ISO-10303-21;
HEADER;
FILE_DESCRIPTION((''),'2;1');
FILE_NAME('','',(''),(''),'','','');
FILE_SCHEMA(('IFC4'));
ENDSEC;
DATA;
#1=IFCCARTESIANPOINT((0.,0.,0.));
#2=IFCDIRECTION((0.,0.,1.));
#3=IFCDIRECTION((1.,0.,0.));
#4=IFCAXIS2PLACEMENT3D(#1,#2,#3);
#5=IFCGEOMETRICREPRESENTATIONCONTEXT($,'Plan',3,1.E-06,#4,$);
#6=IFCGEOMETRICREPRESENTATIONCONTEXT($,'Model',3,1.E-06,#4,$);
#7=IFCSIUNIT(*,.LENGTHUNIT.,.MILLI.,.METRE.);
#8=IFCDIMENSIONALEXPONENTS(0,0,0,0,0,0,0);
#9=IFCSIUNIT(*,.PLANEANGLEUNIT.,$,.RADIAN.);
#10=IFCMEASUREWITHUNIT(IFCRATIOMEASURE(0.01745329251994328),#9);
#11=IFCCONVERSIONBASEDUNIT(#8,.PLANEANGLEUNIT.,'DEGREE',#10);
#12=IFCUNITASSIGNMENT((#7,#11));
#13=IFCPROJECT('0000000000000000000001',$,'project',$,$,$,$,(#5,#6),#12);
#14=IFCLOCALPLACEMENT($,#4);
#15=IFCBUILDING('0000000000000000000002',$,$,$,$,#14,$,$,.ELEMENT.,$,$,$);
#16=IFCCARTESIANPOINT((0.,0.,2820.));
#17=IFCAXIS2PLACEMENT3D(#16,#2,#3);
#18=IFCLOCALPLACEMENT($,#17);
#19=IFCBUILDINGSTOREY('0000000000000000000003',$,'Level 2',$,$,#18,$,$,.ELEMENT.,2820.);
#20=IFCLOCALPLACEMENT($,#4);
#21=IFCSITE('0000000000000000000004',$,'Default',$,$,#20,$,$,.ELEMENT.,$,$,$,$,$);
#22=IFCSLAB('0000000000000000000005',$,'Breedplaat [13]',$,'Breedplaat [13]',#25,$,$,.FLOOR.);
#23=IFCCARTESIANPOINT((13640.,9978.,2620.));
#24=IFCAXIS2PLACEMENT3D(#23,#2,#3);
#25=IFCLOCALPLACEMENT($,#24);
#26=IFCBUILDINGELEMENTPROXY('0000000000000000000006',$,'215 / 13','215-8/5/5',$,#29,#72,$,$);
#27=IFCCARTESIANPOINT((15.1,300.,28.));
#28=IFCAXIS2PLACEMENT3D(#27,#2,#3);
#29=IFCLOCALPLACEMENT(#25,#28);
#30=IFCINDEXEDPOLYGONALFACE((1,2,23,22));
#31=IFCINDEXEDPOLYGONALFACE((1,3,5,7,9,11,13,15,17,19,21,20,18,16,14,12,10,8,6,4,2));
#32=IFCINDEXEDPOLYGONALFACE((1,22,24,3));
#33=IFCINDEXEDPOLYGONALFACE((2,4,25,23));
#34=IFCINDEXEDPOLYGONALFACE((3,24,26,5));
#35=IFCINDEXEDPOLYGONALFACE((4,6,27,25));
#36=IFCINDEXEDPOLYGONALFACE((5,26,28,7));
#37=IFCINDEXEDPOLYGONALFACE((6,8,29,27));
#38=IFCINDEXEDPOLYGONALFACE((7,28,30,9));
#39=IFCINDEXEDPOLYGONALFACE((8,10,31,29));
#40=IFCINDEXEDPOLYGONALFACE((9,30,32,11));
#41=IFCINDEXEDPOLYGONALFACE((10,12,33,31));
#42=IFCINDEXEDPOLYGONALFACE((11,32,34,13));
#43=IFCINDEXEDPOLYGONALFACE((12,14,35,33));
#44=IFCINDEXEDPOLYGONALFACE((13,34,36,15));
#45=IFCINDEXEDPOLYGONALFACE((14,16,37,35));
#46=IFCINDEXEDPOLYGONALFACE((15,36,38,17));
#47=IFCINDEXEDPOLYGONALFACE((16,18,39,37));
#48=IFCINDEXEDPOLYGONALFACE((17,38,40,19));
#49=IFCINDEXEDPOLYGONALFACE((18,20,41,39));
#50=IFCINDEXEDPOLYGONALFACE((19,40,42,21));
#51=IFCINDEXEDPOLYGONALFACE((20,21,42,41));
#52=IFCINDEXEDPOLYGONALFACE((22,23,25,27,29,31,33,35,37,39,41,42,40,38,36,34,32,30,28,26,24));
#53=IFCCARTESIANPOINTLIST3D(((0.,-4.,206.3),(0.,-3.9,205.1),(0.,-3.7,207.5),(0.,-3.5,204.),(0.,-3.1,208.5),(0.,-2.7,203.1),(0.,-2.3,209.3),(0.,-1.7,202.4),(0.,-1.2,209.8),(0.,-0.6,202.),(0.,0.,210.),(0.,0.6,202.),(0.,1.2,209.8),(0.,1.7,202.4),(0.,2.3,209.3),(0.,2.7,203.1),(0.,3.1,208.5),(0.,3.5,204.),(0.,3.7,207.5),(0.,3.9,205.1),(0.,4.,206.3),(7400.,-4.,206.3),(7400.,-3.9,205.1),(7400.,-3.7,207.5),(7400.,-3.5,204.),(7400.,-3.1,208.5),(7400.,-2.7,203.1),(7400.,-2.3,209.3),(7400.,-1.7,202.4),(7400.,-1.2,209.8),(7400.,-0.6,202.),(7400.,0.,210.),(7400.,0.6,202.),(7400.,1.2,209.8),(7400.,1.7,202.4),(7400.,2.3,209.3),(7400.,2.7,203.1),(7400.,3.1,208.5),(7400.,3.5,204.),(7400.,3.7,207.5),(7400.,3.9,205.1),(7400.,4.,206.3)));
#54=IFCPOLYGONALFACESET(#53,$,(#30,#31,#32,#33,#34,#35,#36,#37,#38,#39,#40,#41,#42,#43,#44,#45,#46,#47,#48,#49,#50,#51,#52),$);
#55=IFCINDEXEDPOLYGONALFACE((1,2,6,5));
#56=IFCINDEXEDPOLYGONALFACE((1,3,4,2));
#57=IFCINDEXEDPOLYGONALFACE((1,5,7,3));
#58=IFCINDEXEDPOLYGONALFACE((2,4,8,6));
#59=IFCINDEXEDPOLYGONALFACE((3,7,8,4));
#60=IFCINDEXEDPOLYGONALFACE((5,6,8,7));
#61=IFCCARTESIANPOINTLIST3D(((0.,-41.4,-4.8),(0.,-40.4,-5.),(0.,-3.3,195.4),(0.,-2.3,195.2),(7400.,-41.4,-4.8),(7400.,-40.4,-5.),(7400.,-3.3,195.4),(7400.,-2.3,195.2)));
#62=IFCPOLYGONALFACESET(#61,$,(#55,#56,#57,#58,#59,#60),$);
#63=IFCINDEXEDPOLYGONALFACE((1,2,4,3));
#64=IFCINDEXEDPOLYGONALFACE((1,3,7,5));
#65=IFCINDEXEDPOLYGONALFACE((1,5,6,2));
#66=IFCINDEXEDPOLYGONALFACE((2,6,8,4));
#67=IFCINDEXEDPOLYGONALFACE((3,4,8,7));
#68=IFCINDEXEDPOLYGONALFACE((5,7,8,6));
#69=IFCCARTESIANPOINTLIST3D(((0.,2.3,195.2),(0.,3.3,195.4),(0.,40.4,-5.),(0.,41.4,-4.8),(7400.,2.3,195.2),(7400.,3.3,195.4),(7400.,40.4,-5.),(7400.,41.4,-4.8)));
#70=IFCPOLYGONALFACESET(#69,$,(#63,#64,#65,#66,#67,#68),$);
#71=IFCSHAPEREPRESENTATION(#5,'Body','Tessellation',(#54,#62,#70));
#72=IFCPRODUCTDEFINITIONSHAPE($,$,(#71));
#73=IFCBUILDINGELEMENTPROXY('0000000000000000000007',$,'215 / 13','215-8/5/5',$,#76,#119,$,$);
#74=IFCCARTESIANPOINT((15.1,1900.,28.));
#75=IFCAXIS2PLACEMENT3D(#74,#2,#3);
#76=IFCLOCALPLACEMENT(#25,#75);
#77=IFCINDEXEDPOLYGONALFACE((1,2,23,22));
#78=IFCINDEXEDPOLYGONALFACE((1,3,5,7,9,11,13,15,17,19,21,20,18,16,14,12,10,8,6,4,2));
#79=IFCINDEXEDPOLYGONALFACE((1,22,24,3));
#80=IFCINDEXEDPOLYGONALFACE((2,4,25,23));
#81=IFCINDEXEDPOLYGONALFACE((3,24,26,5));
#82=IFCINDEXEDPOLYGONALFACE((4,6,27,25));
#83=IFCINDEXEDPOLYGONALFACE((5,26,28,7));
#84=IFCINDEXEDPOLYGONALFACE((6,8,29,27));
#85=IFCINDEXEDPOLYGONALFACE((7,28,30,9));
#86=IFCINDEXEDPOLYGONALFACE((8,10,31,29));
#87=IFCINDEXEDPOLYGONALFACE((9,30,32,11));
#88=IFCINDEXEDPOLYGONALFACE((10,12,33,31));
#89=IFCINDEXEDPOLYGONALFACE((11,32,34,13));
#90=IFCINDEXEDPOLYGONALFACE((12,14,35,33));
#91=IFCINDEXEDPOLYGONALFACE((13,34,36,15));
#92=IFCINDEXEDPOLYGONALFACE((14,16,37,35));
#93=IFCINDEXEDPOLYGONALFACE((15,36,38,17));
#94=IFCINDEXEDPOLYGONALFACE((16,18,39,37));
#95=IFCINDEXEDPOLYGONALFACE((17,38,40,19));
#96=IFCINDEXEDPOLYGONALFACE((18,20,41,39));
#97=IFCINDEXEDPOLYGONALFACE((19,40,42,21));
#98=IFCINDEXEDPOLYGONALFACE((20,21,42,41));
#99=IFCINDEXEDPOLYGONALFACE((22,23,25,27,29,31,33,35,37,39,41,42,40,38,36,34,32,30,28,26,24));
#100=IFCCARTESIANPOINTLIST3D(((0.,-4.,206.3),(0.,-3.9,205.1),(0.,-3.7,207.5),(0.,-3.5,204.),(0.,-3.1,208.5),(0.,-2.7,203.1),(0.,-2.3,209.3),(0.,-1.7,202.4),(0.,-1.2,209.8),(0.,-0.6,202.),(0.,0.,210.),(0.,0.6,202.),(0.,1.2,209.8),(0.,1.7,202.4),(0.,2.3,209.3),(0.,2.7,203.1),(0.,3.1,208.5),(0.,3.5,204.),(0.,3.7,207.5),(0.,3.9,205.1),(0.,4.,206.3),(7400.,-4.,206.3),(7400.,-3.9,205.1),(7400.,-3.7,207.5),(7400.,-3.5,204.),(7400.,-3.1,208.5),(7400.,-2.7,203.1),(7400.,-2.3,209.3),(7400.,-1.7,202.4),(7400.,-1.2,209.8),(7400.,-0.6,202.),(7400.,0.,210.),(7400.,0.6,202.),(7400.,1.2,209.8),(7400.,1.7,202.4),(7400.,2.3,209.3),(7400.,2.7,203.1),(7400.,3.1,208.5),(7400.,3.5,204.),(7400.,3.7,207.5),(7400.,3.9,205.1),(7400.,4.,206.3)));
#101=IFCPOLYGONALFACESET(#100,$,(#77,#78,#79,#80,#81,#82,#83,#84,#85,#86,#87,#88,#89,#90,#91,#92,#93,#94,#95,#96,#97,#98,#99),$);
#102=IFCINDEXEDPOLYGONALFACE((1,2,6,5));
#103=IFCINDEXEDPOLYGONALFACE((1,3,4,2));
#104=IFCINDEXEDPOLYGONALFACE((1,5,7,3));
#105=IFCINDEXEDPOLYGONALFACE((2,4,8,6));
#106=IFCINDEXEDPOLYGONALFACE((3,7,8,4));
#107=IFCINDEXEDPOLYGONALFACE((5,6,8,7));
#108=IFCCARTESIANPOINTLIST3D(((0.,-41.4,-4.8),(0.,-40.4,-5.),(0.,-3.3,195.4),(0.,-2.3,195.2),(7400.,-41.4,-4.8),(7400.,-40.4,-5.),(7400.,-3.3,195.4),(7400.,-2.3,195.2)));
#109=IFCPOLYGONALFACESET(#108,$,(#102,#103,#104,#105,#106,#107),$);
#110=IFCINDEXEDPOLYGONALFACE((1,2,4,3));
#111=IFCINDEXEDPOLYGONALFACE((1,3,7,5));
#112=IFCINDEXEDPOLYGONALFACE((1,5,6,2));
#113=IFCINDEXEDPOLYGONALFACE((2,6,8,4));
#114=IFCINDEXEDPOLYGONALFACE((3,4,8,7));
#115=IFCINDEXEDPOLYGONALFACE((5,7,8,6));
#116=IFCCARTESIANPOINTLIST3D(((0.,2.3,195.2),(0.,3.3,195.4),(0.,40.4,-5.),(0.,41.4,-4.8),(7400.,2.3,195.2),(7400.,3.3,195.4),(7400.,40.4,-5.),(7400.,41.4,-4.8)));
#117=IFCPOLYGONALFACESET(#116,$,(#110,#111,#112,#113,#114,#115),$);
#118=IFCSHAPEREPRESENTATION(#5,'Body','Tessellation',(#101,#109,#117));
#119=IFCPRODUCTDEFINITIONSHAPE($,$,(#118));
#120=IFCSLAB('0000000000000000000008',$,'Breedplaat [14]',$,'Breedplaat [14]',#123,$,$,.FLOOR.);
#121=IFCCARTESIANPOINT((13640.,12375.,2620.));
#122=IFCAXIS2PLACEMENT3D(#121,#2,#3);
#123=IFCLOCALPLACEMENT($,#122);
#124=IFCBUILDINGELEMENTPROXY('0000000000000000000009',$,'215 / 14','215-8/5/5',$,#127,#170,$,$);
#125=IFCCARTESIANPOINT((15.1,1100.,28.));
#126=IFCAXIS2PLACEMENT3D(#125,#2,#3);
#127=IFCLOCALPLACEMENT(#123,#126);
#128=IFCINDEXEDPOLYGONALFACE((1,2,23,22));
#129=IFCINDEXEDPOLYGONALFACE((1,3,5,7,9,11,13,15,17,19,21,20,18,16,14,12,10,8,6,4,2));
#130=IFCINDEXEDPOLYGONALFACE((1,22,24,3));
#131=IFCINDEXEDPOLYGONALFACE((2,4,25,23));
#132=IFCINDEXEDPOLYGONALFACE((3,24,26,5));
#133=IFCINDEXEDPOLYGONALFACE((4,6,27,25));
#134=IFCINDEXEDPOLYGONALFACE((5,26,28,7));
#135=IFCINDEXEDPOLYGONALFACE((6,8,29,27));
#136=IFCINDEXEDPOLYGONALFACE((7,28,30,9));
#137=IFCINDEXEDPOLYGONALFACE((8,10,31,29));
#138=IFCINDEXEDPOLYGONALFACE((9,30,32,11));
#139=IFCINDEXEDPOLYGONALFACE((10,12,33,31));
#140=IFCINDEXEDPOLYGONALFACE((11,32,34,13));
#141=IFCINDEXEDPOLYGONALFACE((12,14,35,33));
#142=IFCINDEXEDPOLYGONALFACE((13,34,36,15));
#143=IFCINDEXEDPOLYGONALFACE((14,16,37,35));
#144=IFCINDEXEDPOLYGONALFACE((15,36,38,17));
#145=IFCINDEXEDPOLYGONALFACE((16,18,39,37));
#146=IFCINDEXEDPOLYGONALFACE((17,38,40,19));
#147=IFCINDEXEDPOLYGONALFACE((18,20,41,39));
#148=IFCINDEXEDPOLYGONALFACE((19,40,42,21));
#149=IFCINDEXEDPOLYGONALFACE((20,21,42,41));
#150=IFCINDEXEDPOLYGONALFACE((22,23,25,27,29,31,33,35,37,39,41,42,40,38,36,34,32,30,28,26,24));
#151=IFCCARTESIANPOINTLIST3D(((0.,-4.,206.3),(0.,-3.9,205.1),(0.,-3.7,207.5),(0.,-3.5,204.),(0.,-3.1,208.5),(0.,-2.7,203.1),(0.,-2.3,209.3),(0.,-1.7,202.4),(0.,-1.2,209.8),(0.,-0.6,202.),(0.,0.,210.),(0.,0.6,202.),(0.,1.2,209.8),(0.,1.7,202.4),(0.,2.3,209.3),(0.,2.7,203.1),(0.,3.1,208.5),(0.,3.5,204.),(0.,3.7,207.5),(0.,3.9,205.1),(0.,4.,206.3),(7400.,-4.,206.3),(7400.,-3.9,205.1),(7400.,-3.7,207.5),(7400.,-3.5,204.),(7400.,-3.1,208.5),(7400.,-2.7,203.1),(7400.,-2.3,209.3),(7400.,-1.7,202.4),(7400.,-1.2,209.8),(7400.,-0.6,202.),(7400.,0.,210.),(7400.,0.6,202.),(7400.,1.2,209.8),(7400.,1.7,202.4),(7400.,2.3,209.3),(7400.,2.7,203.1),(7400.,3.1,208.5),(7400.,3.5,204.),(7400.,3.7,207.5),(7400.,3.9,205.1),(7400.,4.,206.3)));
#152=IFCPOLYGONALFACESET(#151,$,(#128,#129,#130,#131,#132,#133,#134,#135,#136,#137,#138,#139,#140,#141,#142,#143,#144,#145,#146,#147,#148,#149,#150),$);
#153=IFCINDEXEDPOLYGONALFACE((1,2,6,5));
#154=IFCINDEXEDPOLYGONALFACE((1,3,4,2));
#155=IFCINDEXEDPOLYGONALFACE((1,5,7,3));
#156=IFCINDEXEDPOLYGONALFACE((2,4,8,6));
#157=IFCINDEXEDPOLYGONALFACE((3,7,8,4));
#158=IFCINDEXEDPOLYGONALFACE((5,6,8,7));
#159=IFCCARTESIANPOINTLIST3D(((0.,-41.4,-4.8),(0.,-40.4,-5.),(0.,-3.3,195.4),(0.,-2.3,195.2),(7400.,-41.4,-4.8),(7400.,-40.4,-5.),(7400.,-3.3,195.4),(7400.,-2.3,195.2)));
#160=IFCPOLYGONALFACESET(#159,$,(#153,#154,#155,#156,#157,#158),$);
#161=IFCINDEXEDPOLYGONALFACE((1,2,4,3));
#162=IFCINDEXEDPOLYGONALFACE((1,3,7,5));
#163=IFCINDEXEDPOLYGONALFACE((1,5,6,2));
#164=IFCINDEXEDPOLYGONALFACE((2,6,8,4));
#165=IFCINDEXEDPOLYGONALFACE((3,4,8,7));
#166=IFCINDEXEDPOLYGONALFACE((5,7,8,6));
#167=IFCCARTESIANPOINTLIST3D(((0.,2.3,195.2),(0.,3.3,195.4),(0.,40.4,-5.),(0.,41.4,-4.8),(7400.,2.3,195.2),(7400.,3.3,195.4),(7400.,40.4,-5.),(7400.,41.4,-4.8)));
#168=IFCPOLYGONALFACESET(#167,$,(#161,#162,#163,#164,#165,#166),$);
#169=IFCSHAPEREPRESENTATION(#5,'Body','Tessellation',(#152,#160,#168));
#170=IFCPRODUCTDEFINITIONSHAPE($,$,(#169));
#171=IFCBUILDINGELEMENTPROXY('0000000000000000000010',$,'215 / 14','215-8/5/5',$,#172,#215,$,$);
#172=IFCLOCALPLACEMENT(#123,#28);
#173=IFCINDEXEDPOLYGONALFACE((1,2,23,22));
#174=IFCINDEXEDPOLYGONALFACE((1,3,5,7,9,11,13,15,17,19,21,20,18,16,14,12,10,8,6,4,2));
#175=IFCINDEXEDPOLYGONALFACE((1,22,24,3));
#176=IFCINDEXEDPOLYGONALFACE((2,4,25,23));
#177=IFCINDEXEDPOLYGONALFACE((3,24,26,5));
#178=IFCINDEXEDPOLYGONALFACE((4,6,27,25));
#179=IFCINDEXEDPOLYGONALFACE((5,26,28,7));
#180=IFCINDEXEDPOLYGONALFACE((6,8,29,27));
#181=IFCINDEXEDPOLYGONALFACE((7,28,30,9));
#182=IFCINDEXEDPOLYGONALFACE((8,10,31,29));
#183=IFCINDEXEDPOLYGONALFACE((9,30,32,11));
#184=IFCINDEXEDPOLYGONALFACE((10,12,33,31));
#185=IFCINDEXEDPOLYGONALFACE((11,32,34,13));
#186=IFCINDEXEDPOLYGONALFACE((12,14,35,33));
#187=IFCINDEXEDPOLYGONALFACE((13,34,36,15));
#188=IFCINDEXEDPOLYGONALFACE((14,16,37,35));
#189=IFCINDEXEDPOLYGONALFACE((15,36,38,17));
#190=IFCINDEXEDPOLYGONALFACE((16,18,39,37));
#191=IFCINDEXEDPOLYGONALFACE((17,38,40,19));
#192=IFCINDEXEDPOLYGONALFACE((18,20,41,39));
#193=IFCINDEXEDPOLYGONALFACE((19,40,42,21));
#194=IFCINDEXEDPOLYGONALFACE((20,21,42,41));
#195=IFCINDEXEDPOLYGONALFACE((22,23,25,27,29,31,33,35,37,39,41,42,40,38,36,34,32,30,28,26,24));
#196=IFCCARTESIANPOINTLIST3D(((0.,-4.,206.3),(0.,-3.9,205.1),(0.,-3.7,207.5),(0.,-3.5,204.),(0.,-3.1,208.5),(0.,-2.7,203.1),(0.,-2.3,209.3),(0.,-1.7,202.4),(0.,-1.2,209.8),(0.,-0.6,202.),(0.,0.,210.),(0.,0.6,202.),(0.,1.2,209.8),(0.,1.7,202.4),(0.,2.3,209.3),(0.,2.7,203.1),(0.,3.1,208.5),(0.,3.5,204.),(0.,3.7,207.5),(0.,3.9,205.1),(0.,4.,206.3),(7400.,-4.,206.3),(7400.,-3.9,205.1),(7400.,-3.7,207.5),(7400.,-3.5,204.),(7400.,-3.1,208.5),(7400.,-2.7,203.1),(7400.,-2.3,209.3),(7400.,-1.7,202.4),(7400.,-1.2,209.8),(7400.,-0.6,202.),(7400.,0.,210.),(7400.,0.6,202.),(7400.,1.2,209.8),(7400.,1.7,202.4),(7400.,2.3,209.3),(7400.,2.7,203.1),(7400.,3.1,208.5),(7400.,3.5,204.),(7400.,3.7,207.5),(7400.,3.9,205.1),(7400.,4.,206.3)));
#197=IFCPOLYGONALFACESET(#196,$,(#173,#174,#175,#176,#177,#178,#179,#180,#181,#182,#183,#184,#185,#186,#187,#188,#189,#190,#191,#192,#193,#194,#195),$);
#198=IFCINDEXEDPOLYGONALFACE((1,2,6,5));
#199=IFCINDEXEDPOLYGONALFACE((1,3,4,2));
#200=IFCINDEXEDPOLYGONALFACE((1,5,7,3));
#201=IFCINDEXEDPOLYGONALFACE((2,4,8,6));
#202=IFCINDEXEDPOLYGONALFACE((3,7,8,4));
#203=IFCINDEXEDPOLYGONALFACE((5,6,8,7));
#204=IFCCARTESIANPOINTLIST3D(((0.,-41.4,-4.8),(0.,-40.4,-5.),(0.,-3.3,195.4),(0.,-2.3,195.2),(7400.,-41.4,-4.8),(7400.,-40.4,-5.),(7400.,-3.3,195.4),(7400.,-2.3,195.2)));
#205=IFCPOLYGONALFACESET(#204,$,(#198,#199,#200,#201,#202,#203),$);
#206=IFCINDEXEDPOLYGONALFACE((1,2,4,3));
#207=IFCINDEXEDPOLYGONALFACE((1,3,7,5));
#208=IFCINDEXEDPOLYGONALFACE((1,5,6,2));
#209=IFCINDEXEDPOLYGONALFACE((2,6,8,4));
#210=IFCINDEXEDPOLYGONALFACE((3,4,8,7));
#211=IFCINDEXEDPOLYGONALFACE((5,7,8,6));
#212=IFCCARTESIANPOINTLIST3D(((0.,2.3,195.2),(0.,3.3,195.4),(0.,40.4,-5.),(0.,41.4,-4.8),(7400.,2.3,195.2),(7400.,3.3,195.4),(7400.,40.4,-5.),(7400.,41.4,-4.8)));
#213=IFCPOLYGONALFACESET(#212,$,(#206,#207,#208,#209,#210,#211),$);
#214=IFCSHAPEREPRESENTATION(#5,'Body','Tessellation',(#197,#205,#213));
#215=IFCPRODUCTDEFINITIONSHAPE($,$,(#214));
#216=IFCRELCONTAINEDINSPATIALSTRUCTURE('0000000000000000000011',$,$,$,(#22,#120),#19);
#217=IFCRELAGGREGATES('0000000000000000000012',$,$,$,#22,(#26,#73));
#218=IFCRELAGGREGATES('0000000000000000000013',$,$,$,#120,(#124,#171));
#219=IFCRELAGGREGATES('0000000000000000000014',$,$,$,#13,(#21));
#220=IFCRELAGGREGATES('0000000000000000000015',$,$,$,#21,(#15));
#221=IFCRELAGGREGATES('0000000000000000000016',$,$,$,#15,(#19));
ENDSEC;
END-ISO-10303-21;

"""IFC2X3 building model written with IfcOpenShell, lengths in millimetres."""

from ifc_helpers import new_model, entity, si_unit, converted_unit, frame, origin_with_axes, origin_2d_with_axis, place, context, project, spatial, rectangle, circle, extrude, element, aggregate, save


model = new_model("IFC2X3")

# Units and contexts
plan_context = context("Plan", 3, precision=1e-06, world=origin_with_axes())
model_context = context("Model", 3, precision=1e-06, world=origin_with_axes())
ifc_project = project(units=[si_unit("LENGTHUNIT", "METRE", prefix="MILLI"), converted_unit("PLANEANGLEUNIT", "DEGREE", entity("IfcRatioMeasure", 0.01745329251994328), si_unit("PLANEANGLEUNIT", "RADIAN"), dimensions=[0, 0, 0, 0, 0, 0, 0])], contexts=[plan_context, model_context])

# Site, building, storey
site_placement = place(None, origin_with_axes())
site = spatial("IfcSite", under=ifc_project, at=site_placement, Name="Default", CompositionType="ELEMENT")
building_placement = place(None, origin_with_axes())
building = spatial("IfcBuilding", under=site, at=building_placement, CompositionType="ELEMENT")
storey_placement = place(None, frame((0.0, 0.0, 2820.0), z_axis=(0.0, 0.0, 1.0), x_axis=(1.0, 0.0, 0.0)))
storey = spatial("IfcBuildingStorey", under=building, at=storey_placement, Name="Level 2", CompositionType="ELEMENT", Elevation=2820.0)

# Slabs, building element proxies
slab_1_placement = place(None, frame((13640.0, 9978.0, 2620.0), z_axis=(0.0, 0.0, 1.0), x_axis=(1.0, 0.0, 0.0)))
slab_1 = element("IfcSlab", 1, at=slab_1_placement, inside=storey, Name="Breedplaat [13]", ObjectType="Breedplaat [13]", PredefinedType="FLOOR")
proxy_1_placement = place(slab_1_placement, frame((15.1, 300.0, 28.0), z_axis=(0.0, 0.0, 1.0), x_axis=(1.0, 0.0, 0.0)))
proxy_1 = element("IfcBuildingElementProxy", 2, at=proxy_1_placement, Name="215 / 13", Description="215-8/5/5", context=plan_context, shape_type="SweptSolid", body=[
    extrude(circle(Radius=4.0, at=origin_2d_with_axis()), frame((0.0, 0.0, 206.0), z_axis=(1.0, 0.0, 0.0), x_axis=(0.0, 0.0, 1.0)), (0.0, 0.0, 1.0), 7400.0),
    extrude(rectangle(XDim=203.8, YDim=1.0, at=origin_2d_with_axis()), frame((0.0, -21.9, 95.2), z_axis=(1.0, 0.0, 0.0), x_axis=(0.0, 0.187112, 0.982339)), (0.0, 0.0, 1.0), 7400.0),
    extrude(rectangle(XDim=203.8, YDim=1.0, at=origin_2d_with_axis()), frame((0.0, 21.9, 95.2), z_axis=(1.0, 0.0, 0.0), x_axis=(0.0, -0.187112, 0.982339)), (0.0, 0.0, 1.0), 7400.0),
])
proxy_2_placement = place(slab_1_placement, frame((15.1, 1900.0, 28.0), z_axis=(0.0, 0.0, 1.0), x_axis=(1.0, 0.0, 0.0)))
proxy_2 = element("IfcBuildingElementProxy", 3, at=proxy_2_placement, Name="215 / 13", Description="215-8/5/5", context=plan_context, shape_type="SweptSolid", body=[
    extrude(circle(Radius=4.0, at=origin_2d_with_axis()), frame((0.0, 0.0, 206.0), z_axis=(1.0, 0.0, 0.0), x_axis=(0.0, 0.0, 1.0)), (0.0, 0.0, 1.0), 7400.0),
    extrude(rectangle(XDim=203.8, YDim=1.0, at=origin_2d_with_axis()), frame((0.0, -21.9, 95.2), z_axis=(1.0, 0.0, 0.0), x_axis=(0.0, 0.187112, 0.982339)), (0.0, 0.0, 1.0), 7400.0),
    extrude(rectangle(XDim=203.8, YDim=1.0, at=origin_2d_with_axis()), frame((0.0, 21.9, 95.2), z_axis=(1.0, 0.0, 0.0), x_axis=(0.0, -0.187112, 0.982339)), (0.0, 0.0, 1.0), 7400.0),
])
aggregate(slab_1, [proxy_1, proxy_2])
slab_2_placement = place(None, frame((13640.0, 12375.0, 2620.0), z_axis=(0.0, 0.0, 1.0), x_axis=(1.0, 0.0, 0.0)))
slab_2 = element("IfcSlab", 4, at=slab_2_placement, inside=storey, Name="Breedplaat [14]", ObjectType="Breedplaat [14]", PredefinedType="FLOOR")
proxy_3_placement = place(slab_2_placement, frame((15.1, 1100.0, 28.0), z_axis=(0.0, 0.0, 1.0), x_axis=(1.0, 0.0, 0.0)))
proxy_3 = element("IfcBuildingElementProxy", 5, at=proxy_3_placement, Name="215 / 14", Description="215-8/5/5", context=plan_context, shape_type="SweptSolid", body=[
    extrude(circle(Radius=4.0, at=origin_2d_with_axis()), frame((0.0, 0.0, 206.0), z_axis=(1.0, 0.0, 0.0), x_axis=(0.0, 0.0, 1.0)), (0.0, 0.0, 1.0), 7400.0),
    extrude(rectangle(XDim=203.8, YDim=1.0, at=origin_2d_with_axis()), frame((0.0, -21.9, 95.2), z_axis=(1.0, 0.0, 0.0), x_axis=(0.0, 0.187112, 0.982339)), (0.0, 0.0, 1.0), 7400.0),
    extrude(rectangle(XDim=203.8, YDim=1.0, at=origin_2d_with_axis()), frame((0.0, 21.9, 95.2), z_axis=(1.0, 0.0, 0.0), x_axis=(0.0, -0.187112, 0.982339)), (0.0, 0.0, 1.0), 7400.0),
])
proxy_4_placement = place(slab_2_placement, frame((15.1, 300.0, 28.0), z_axis=(0.0, 0.0, 1.0), x_axis=(1.0, 0.0, 0.0)))
proxy_4 = element("IfcBuildingElementProxy", 6, at=proxy_4_placement, Name="215 / 14", Description="215-8/5/5", context=plan_context, shape_type="SweptSolid", body=[
    extrude(circle(Radius=4.0, at=origin_2d_with_axis()), frame((0.0, 0.0, 206.0), z_axis=(1.0, 0.0, 0.0), x_axis=(0.0, 0.0, 1.0)), (0.0, 0.0, 1.0), 7400.0),
    extrude(rectangle(XDim=203.8, YDim=1.0, at=origin_2d_with_axis()), frame((0.0, -21.9, 95.2), z_axis=(1.0, 0.0, 0.0), x_axis=(0.0, 0.187112, 0.982339)), (0.0, 0.0, 1.0), 7400.0),
    extrude(rectangle(XDim=203.8, YDim=1.0, at=origin_2d_with_axis()), frame((0.0, 21.9, 95.2), z_axis=(1.0, 0.0, 0.0), x_axis=(0.0, -0.187112, 0.982339)), (0.0, 0.0, 1.0), 7400.0),
])
aggregate(slab_2, [proxy_3, proxy_4])

save(model, "model.ifc")
